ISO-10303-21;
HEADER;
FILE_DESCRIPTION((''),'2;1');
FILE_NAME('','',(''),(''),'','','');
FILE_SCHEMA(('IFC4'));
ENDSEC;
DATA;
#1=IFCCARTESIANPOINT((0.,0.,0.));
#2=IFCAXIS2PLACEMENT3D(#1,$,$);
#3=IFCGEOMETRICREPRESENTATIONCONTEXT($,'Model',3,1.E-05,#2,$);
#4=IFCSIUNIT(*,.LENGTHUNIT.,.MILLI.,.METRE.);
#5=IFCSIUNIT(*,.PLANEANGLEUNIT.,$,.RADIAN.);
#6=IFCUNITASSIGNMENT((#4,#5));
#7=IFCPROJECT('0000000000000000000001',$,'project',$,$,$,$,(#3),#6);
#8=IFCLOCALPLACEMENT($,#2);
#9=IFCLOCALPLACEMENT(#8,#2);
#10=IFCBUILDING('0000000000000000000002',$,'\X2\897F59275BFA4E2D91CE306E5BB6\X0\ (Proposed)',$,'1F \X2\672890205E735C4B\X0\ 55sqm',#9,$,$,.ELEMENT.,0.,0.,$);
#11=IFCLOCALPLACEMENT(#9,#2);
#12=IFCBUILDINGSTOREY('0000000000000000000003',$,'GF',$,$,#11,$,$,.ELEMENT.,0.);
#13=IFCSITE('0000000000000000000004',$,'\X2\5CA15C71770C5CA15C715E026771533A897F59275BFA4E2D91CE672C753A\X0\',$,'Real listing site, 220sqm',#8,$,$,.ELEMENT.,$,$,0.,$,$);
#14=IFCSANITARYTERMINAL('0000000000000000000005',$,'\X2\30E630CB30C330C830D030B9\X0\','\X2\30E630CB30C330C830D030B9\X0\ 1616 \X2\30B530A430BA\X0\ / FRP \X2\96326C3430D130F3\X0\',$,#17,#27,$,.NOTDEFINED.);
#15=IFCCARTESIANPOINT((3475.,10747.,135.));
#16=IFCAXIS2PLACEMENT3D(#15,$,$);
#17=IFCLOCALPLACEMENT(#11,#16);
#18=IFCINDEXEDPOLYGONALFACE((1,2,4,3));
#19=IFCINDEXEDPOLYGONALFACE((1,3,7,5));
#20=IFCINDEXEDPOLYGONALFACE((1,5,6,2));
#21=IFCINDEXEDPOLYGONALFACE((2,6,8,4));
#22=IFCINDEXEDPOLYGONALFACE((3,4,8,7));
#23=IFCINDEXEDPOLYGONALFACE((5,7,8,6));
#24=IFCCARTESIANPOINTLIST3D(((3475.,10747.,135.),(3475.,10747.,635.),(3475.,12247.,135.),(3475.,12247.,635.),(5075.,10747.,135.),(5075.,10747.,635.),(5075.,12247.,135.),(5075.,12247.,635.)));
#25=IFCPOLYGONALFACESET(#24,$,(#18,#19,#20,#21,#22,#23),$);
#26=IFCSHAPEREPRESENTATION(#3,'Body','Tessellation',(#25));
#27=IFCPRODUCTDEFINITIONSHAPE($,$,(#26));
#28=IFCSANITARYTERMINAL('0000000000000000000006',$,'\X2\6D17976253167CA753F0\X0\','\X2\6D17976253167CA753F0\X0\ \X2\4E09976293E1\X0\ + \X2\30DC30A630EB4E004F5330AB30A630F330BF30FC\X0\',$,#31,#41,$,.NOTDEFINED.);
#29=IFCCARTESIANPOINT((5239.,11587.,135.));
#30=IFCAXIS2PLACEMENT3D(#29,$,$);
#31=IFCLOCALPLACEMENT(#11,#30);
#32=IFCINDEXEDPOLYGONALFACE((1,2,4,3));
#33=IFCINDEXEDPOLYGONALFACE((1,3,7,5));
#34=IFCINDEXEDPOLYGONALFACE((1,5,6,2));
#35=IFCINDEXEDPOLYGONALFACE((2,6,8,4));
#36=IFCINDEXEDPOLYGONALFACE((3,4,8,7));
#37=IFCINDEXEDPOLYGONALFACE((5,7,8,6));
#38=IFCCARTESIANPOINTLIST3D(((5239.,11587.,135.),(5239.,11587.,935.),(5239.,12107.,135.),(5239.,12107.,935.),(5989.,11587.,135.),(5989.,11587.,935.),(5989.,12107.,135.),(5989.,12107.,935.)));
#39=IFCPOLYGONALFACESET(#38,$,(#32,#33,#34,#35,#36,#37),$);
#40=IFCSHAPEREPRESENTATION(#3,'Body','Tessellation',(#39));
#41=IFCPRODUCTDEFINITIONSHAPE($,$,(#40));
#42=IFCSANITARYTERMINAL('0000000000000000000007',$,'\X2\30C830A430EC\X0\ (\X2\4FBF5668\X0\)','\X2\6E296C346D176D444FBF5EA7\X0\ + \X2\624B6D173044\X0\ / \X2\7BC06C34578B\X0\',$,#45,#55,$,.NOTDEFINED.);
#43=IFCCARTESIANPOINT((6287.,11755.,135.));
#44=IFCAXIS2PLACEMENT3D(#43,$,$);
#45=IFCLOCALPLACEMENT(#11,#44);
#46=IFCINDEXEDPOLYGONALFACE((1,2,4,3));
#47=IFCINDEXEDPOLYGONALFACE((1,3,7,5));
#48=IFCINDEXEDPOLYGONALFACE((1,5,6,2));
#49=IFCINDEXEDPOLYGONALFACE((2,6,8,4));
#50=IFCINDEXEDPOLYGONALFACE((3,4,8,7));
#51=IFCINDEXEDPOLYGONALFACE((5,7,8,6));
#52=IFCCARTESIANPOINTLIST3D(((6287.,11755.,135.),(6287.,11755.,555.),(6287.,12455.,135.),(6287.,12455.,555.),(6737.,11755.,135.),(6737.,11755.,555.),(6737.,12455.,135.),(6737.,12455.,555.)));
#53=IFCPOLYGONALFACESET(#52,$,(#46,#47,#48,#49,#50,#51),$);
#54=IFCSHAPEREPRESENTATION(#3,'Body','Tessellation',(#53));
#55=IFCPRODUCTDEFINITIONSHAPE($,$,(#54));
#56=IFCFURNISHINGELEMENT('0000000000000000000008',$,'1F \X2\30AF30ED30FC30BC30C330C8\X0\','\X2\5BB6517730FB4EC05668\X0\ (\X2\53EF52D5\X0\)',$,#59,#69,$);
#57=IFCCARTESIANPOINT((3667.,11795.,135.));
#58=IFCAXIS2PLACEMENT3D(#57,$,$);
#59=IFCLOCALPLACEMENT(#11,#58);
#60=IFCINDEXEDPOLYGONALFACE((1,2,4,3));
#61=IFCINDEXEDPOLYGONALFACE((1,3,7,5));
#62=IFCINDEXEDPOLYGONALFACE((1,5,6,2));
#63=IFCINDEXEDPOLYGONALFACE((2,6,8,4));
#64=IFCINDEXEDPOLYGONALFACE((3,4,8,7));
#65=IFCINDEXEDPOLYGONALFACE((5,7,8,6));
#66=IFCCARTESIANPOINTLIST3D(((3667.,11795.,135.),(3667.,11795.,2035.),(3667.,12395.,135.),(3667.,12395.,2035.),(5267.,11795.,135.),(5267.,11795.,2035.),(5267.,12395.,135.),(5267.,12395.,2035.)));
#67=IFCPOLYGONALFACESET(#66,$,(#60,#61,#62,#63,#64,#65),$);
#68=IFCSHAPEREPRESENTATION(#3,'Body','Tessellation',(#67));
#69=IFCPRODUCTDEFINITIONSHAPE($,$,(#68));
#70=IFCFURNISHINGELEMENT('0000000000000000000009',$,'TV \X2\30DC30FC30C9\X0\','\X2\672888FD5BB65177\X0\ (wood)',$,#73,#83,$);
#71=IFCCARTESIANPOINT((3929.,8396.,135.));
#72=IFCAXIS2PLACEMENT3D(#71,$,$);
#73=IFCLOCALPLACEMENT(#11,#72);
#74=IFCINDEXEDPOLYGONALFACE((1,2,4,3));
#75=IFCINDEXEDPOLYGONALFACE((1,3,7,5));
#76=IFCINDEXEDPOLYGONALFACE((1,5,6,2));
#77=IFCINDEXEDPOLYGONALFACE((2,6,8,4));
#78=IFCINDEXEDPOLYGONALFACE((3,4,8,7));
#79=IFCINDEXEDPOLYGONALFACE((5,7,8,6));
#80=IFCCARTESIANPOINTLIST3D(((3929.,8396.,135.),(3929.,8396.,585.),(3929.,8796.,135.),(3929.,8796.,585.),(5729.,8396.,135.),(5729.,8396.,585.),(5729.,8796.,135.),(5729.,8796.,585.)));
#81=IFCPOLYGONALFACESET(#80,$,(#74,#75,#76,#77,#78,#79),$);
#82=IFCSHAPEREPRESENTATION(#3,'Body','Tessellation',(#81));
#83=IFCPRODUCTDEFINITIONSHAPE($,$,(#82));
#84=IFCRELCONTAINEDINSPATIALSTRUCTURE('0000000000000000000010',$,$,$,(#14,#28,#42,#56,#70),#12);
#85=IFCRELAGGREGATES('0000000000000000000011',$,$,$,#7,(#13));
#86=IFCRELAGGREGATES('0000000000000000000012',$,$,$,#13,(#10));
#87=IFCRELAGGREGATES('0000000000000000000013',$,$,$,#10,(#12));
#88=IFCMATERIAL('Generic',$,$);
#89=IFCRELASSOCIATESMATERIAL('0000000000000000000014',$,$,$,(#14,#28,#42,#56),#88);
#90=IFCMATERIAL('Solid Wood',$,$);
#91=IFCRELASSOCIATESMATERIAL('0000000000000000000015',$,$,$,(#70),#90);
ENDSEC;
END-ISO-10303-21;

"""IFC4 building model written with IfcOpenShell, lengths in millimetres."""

from ifc_helpers import new_model, si_unit, frame, frame_2d, origin, place, context, project, spatial, rectangle, extrude, material, element, save


model = new_model("IFC4")

# Units and contexts
model_context = context("Model", 3, precision=1e-05, world=origin())
ifc_project = project(units=[si_unit("LENGTHUNIT", "METRE", prefix="MILLI"), si_unit("PLANEANGLEUNIT", "RADIAN")], contexts=[model_context])

# Site, building, storey
site_placement = place(None, origin())
site = spatial("IfcSite", under=ifc_project, at=site_placement, Name="岡山県岡山市東区西大寺中野本町", ObjectType="Real listing site, 220sqm", CompositionType="ELEMENT", RefElevation=0.0)
building_placement = place(site_placement, origin())
building = spatial("IfcBuilding", under=site, at=building_placement, Name="西大寺中野の家 (Proposed)", ObjectType="1F 木造平屋 55sqm", CompositionType="ELEMENT", ElevationOfRefHeight=0.0, ElevationOfTerrain=0.0)
storey_placement = place(building_placement, origin())
storey = spatial("IfcBuildingStorey", under=building, at=storey_placement, Name="GF", CompositionType="ELEMENT", Elevation=0.0)

# Shared definitions
ifc_material_1 = material(Name="Solid Wood")

# Shared definitions
ifc_material_2 = material(Name="Generic")

# Sanitary terminals
sanitary_terminal_1_placement = place(storey_placement, frame((3475.0, 10747.0, 135.0)))
element("IfcSanitaryTerminal", 1, at=sanitary_terminal_1_placement, inside=storey, material=ifc_material_2, Name="ユニットバス", Description="ユニットバス 1616 サイズ / FRP 防水パン", PredefinedType="NOTDEFINED", context=model_context, shape_type="SweptSolid", body=[
    extrude(rectangle(XDim=1600.0, YDim=1500.0, at=frame_2d((800.0, 750.0))), frame((3475.0, 10747.0, 135.0)), (0.0, 0.0, 1.0), 500.0),
])
sanitary_terminal_2_placement = place(storey_placement, frame((5239.0, 11587.0, 135.0)))
element("IfcSanitaryTerminal", 2, at=sanitary_terminal_2_placement, inside=storey, material=ifc_material_2, Name="洗面化粧台", Description="洗面化粧台 三面鏡 + ボウル一体カウンター", PredefinedType="NOTDEFINED", context=model_context, shape_type="SweptSolid", body=[
    extrude(rectangle(XDim=750.0, YDim=520.0, at=frame_2d((375.0, 260.0))), frame((5239.0, 11587.0, 135.0)), (0.0, 0.0, 1.0), 800.0),
])
sanitary_terminal_3_placement = place(storey_placement, frame((6287.0, 11755.0, 135.0)))
element("IfcSanitaryTerminal", 3, at=sanitary_terminal_3_placement, inside=storey, material=ifc_material_2, Name="トイレ (便器)", Description="温水洗浄便座 + 手洗い / 節水型", PredefinedType="NOTDEFINED", context=model_context, shape_type="SweptSolid", body=[
    extrude(rectangle(XDim=450.0, YDim=700.0, at=frame_2d((225.0, 350.0))), frame((6287.0, 11755.0, 135.0)), (0.0, 0.0, 1.0), 420.0),
])

# Furnishing elements
furnishing_1_placement = place(storey_placement, frame((3667.0, 11795.0, 135.0)))
element("IfcFurnishingElement", 4, at=furnishing_1_placement, inside=storey, material=ifc_material_2, Name="1F クローゼット", Description="家具・什器 (可動)", context=model_context, shape_type="SweptSolid", body=[
    extrude(rectangle(XDim=1600.0, YDim=600.0, at=frame_2d((800.0, 300.0))), frame((3667.0, 11795.0, 135.0)), (0.0, 0.0, 1.0), 1900.0),
])
furnishing_2_placement = place(storey_placement, frame((3929.0, 8396.0, 135.0)))
element("IfcFurnishingElement", 5, at=furnishing_2_placement, inside=storey, material=ifc_material_1, Name="TV ボード", Description="木製家具 (wood)", context=model_context, shape_type="SweptSolid", body=[
    extrude(rectangle(XDim=1800.0, YDim=400.0, at=frame_2d((900.0, 200.0))), frame((3929.0, 8396.0, 135.0)), (0.0, 0.0, 1.0), 450.0),
])

save(model, "model.ifc")
